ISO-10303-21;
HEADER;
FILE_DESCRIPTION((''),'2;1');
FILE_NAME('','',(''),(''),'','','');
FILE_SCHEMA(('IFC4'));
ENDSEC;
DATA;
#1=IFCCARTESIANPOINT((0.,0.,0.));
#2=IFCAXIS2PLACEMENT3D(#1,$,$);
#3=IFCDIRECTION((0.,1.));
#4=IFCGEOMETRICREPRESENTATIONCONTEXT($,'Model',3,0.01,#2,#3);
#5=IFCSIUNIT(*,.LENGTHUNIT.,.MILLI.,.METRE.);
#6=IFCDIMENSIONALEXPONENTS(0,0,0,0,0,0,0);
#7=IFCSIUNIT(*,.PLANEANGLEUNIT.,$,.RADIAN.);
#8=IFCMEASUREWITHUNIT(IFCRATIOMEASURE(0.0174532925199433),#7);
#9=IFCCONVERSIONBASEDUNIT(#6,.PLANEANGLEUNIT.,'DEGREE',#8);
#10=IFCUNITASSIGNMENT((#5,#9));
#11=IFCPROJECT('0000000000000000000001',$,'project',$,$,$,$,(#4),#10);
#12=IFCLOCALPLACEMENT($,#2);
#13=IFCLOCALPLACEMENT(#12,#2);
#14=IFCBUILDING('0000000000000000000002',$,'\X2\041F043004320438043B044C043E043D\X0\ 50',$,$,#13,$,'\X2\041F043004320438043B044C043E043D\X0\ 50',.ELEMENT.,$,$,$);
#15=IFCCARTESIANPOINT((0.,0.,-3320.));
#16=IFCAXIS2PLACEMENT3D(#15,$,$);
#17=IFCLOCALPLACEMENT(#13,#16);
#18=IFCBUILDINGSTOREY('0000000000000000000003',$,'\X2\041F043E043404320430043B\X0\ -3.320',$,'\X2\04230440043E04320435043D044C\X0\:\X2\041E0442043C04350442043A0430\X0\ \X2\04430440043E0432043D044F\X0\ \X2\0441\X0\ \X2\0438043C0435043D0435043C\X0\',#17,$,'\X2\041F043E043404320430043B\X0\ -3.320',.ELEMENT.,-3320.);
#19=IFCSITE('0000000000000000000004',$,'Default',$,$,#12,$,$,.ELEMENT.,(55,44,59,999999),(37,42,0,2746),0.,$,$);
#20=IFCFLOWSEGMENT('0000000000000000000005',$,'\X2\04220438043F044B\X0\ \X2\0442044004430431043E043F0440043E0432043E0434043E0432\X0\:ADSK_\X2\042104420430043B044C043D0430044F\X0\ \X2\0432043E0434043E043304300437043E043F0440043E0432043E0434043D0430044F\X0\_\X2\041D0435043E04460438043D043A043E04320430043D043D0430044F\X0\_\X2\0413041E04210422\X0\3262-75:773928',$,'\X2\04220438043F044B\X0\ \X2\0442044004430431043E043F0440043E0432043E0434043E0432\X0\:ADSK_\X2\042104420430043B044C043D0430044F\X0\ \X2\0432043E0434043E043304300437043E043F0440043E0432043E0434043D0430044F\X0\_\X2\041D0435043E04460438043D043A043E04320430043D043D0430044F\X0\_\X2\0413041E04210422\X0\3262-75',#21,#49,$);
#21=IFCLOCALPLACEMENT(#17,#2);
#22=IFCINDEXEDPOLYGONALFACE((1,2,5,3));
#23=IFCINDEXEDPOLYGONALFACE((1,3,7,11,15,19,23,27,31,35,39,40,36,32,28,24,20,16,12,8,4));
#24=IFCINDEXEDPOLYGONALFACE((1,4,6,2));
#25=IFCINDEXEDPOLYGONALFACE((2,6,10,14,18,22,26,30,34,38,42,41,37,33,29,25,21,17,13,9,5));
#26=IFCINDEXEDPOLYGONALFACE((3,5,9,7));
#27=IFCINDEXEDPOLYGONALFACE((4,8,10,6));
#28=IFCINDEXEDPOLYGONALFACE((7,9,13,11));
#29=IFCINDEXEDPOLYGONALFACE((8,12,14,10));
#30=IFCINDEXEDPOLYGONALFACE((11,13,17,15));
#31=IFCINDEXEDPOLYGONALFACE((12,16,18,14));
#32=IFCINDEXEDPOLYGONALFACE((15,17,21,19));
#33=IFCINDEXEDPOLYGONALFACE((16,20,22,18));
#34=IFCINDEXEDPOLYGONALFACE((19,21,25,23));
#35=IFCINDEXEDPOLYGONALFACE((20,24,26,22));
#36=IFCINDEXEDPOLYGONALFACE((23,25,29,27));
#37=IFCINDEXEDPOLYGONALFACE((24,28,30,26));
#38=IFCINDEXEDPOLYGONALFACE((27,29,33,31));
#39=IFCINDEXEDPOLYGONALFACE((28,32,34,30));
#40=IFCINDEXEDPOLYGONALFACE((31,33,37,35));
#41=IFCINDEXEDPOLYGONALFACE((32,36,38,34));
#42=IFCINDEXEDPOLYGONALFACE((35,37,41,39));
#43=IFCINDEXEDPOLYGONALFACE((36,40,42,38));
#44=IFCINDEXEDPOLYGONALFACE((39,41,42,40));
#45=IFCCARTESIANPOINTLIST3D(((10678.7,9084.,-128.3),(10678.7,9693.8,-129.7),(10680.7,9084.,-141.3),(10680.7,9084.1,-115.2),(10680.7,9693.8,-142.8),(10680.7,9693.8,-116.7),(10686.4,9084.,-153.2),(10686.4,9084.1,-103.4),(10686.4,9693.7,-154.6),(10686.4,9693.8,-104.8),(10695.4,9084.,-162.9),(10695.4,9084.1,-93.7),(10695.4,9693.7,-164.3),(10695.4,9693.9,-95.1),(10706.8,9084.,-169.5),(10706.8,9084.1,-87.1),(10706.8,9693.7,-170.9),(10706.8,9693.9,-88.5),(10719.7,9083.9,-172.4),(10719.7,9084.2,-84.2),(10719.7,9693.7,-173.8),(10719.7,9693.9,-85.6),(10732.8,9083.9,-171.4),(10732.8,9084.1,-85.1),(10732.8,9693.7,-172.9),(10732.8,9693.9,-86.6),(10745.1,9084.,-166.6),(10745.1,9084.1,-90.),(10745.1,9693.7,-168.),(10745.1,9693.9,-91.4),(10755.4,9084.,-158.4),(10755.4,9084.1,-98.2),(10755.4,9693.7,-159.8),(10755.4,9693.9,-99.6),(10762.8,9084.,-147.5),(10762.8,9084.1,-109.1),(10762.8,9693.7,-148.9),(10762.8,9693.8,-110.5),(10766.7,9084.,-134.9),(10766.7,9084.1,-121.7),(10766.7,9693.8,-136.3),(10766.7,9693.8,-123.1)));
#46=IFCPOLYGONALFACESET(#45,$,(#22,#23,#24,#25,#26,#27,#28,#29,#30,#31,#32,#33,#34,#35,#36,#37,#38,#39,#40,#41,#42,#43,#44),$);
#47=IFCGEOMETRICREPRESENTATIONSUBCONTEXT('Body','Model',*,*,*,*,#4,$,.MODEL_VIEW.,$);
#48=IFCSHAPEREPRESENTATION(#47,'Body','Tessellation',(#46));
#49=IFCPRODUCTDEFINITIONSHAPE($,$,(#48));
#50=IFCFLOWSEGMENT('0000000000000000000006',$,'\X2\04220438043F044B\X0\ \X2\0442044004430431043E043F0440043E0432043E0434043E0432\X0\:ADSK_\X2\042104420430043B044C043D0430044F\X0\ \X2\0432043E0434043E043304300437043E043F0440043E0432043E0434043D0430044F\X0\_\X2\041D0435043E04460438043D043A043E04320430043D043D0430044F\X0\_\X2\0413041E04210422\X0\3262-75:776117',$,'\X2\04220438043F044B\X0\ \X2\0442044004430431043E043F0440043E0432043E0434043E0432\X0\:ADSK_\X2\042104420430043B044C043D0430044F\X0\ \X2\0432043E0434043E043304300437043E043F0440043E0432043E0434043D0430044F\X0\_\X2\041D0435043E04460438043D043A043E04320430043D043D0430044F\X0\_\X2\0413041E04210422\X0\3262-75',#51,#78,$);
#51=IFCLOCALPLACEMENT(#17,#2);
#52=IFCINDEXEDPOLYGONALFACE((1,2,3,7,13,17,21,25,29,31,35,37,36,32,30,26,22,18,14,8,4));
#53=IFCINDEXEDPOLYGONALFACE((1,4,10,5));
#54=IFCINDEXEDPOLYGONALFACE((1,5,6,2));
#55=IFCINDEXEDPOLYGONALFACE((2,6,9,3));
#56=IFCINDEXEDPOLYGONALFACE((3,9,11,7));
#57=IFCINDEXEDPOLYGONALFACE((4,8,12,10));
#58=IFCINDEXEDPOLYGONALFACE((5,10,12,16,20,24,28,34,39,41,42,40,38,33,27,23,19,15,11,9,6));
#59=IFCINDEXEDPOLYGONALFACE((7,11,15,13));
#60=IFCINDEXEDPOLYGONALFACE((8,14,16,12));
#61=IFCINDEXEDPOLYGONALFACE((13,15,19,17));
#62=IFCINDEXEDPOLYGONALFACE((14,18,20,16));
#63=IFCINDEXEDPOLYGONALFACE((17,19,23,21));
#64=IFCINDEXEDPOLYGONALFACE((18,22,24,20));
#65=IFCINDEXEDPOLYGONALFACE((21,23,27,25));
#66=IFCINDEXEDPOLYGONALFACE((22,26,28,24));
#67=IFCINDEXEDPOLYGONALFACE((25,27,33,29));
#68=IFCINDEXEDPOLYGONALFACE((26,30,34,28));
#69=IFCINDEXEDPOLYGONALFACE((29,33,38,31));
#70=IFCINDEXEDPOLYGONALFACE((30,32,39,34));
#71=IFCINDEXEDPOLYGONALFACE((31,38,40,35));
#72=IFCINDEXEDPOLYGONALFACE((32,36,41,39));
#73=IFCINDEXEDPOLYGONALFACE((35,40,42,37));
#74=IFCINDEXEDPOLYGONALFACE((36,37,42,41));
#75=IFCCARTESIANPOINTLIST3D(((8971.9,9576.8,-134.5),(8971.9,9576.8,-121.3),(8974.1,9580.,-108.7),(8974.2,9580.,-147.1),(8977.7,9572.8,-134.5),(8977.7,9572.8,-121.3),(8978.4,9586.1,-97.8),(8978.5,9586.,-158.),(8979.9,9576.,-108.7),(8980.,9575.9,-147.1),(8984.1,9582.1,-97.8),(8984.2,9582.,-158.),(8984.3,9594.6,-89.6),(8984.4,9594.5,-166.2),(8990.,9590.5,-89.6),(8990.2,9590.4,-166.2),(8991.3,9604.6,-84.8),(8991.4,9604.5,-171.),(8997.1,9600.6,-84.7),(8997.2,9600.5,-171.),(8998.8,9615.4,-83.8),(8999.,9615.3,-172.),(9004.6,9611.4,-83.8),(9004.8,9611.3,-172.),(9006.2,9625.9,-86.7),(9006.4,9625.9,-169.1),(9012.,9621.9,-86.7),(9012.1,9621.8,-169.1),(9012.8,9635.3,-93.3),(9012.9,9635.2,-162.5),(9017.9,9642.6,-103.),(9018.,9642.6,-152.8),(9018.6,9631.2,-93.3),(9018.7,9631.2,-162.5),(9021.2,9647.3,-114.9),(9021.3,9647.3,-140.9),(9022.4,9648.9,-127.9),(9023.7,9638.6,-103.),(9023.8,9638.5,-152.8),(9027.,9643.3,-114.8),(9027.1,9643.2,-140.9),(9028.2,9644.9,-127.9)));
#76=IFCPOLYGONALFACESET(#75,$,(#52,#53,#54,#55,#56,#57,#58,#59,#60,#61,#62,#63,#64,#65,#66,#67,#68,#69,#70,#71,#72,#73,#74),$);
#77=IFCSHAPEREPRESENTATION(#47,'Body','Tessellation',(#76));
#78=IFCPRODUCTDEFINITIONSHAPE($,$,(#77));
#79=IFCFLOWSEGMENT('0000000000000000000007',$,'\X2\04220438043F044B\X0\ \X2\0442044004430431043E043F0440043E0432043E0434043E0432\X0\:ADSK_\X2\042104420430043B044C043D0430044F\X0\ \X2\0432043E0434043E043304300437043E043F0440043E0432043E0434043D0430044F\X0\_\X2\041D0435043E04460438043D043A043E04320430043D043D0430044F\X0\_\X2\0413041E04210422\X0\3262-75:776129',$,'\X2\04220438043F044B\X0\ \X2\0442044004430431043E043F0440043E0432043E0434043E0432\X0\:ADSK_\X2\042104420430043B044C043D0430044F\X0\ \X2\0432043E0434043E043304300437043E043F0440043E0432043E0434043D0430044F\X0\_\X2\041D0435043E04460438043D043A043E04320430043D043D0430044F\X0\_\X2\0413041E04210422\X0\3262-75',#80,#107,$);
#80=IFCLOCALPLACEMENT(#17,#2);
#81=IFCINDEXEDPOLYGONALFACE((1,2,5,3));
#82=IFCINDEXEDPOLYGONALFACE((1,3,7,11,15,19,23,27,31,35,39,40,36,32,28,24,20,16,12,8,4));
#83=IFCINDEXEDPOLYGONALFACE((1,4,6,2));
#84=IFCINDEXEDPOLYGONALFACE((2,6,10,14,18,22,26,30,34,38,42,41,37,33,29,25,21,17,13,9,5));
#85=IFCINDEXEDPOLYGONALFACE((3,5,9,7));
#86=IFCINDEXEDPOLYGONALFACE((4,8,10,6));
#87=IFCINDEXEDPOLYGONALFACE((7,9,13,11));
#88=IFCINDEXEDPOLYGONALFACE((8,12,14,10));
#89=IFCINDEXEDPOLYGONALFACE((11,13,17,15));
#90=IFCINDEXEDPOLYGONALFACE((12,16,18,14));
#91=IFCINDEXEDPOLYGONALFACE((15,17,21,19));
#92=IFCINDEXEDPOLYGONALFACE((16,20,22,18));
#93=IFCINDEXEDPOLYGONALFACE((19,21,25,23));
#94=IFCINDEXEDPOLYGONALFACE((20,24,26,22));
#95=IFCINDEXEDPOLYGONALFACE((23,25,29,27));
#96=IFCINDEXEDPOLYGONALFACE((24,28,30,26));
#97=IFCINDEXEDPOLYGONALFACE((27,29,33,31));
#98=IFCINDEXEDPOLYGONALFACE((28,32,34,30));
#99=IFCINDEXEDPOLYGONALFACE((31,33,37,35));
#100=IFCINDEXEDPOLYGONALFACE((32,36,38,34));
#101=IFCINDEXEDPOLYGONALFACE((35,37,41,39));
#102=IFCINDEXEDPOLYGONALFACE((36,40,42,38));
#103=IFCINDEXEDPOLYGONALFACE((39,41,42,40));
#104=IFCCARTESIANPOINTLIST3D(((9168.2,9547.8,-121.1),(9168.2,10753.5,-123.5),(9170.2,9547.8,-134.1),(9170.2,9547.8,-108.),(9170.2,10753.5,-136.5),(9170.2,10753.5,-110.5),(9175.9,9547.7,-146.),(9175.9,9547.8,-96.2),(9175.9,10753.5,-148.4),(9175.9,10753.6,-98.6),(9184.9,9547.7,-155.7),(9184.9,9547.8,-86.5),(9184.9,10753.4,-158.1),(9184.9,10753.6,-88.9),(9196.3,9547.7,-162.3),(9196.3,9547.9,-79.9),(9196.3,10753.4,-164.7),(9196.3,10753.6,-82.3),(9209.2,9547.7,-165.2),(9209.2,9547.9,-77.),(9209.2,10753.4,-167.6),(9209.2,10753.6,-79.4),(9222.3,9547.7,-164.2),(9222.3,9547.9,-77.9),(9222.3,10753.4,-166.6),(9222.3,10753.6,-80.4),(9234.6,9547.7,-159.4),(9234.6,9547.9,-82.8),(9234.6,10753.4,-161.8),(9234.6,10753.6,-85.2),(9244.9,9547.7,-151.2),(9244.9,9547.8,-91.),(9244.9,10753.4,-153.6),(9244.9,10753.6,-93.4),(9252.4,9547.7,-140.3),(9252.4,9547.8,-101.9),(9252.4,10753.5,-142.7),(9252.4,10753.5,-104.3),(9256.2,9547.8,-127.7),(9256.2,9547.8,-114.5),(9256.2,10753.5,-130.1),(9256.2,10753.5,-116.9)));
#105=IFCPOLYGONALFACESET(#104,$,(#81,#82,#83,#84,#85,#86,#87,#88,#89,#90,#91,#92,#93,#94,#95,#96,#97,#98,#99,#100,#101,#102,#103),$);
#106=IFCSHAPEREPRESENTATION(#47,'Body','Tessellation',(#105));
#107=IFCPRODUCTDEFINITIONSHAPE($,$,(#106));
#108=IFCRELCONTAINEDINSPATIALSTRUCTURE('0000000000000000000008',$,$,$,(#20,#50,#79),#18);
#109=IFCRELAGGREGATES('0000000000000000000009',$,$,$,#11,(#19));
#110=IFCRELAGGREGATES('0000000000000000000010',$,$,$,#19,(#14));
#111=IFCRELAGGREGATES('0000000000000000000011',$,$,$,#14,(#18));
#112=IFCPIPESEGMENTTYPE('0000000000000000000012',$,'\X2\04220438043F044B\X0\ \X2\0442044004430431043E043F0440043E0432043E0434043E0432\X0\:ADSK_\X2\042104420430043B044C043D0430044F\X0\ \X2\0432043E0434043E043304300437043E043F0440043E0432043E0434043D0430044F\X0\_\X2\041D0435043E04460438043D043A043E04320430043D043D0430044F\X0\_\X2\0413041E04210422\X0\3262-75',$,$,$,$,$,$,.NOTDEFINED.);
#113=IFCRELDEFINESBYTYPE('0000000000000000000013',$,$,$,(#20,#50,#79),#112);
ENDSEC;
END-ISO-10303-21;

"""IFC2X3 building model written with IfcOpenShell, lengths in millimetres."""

from ifc_helpers import new_model, entity, si_unit, converted_unit, direction, frame, frame_2d, origin, origin_2d_with_axis, place, context, subcontext, project, spatial, circle, extrude, type_object, element, save


model = new_model("IFC2X3")

# Units and contexts
model_context = context("Model", 3, precision=0.01, world=origin(), true_north=direction((0.0, 1.0)))
body_context = subcontext(model_context, "Body", "Model", "MODEL_VIEW")
ifc_project = project(units=[si_unit("LENGTHUNIT", "METRE", prefix="MILLI"), converted_unit("PLANEANGLEUNIT", "DEGREE", entity("IfcRatioMeasure", 0.0174532925199433), si_unit("PLANEANGLEUNIT", "RADIAN"), dimensions=[0, 0, 0, 0, 0, 0, 0])], contexts=[model_context])

# Site, building, storey
site_placement = place(None, origin())
site = spatial("IfcSite", under=ifc_project, at=site_placement, Name="Default", CompositionType="ELEMENT", RefLatitude=(55, 44, 59, 999999), RefLongitude=(37, 42, 0, 2746), RefElevation=0.0)
building_placement = place(site_placement, origin())
building = spatial("IfcBuilding", under=site, at=building_placement, Name="Павильон 50", LongName="Павильон 50", CompositionType="ELEMENT")
storey_placement = place(building_placement, frame((0.0, 0.0, -3320.0)))
storey = spatial("IfcBuildingStorey", under=building, at=storey_placement, Name="Подвал -3.320", ObjectType="Уровень:Отметка уровня с именем", LongName="Подвал -3.320", CompositionType="ELEMENT", Elevation=-3320.0)

# Flow segments
pipe_segment_type = type_object("IfcPipeSegmentType", Name="Типы трубопроводов:ADSK_Стальная водогазопроводная_Неоцинкованная_ГОСТ3262-75", PredefinedType="NOTDEFINED")
flow_segment_1_placement = place(storey_placement, frame((10677.1, 9083.9, -175.6)))
element("IfcFlowSegment", 1, at=flow_segment_1_placement, inside=storey, type_object=pipe_segment_type, Name="Типы трубопроводов:ADSK_Стальная водогазопроводная_Неоцинкованная_ГОСТ3262-75:773928", ObjectType="Типы трубопроводов:ADSK_Стальная водогазопроводная_Неоцинкованная_ГОСТ3262-75", context=body_context, shape_type="SweptSolid", body=[
    extrude(circle(Radius=44.2, at=origin_2d_with_axis()), frame((45.8, 0.1, 47.3), z_axis=(0.0, 0.999997, -0.002331), x_axis=(-1.0, 0.0, 0.0)), (0.0, 0.0, 1.0), 609.7),
])
flow_segment_2_placement = place(storey_placement, frame((8970.0, 9570.8, -173.7)))
element("IfcFlowSegment", 2, at=flow_segment_2_placement, inside=storey, type_object=pipe_segment_type, Name="Типы трубопроводов:ADSK_Стальная водогазопроводная_Неоцинкованная_ГОСТ3262-75:776117", ObjectType="Типы трубопроводов:ADSK_Стальная водогазопроводная_Неоцинкованная_ГОСТ3262-75", context=body_context, shape_type="SweptSolid", body=[
    extrude(circle(Radius=44.2, at=frame_2d((0.0, 0.0), x_axis=(1.0, 0.0))), frame((27.0, 41.9, 45.8), z_axis=(0.81915, -0.573575, 0.002), x_axis=(0.573576, 0.819152, 0.0)), (0.0, 0.0, 1.0), 7.1),
])
flow_segment_3_placement = place(storey_placement, frame((9166.6, 9547.7, -169.3)))
element("IfcFlowSegment", 3, at=flow_segment_3_placement, inside=storey, type_object=pipe_segment_type, Name="Типы трубопроводов:ADSK_Стальная водогазопроводная_Неоцинкованная_ГОСТ3262-75:776129", ObjectType="Типы трубопроводов:ADSK_Стальная водогазопроводная_Неоцинкованная_ГОСТ3262-75", context=body_context, shape_type="SweptSolid", body=[
    extrude(circle(Radius=44.2, at=origin_2d_with_axis()), frame((45.8, 1205.8, 45.8), z_axis=(0.0, -0.999998, 0.002), x_axis=(-1.0, 0.0, 0.0)), (0.0, 0.0, 1.0), 1205.7),
])

save(model, "model.ifc")
